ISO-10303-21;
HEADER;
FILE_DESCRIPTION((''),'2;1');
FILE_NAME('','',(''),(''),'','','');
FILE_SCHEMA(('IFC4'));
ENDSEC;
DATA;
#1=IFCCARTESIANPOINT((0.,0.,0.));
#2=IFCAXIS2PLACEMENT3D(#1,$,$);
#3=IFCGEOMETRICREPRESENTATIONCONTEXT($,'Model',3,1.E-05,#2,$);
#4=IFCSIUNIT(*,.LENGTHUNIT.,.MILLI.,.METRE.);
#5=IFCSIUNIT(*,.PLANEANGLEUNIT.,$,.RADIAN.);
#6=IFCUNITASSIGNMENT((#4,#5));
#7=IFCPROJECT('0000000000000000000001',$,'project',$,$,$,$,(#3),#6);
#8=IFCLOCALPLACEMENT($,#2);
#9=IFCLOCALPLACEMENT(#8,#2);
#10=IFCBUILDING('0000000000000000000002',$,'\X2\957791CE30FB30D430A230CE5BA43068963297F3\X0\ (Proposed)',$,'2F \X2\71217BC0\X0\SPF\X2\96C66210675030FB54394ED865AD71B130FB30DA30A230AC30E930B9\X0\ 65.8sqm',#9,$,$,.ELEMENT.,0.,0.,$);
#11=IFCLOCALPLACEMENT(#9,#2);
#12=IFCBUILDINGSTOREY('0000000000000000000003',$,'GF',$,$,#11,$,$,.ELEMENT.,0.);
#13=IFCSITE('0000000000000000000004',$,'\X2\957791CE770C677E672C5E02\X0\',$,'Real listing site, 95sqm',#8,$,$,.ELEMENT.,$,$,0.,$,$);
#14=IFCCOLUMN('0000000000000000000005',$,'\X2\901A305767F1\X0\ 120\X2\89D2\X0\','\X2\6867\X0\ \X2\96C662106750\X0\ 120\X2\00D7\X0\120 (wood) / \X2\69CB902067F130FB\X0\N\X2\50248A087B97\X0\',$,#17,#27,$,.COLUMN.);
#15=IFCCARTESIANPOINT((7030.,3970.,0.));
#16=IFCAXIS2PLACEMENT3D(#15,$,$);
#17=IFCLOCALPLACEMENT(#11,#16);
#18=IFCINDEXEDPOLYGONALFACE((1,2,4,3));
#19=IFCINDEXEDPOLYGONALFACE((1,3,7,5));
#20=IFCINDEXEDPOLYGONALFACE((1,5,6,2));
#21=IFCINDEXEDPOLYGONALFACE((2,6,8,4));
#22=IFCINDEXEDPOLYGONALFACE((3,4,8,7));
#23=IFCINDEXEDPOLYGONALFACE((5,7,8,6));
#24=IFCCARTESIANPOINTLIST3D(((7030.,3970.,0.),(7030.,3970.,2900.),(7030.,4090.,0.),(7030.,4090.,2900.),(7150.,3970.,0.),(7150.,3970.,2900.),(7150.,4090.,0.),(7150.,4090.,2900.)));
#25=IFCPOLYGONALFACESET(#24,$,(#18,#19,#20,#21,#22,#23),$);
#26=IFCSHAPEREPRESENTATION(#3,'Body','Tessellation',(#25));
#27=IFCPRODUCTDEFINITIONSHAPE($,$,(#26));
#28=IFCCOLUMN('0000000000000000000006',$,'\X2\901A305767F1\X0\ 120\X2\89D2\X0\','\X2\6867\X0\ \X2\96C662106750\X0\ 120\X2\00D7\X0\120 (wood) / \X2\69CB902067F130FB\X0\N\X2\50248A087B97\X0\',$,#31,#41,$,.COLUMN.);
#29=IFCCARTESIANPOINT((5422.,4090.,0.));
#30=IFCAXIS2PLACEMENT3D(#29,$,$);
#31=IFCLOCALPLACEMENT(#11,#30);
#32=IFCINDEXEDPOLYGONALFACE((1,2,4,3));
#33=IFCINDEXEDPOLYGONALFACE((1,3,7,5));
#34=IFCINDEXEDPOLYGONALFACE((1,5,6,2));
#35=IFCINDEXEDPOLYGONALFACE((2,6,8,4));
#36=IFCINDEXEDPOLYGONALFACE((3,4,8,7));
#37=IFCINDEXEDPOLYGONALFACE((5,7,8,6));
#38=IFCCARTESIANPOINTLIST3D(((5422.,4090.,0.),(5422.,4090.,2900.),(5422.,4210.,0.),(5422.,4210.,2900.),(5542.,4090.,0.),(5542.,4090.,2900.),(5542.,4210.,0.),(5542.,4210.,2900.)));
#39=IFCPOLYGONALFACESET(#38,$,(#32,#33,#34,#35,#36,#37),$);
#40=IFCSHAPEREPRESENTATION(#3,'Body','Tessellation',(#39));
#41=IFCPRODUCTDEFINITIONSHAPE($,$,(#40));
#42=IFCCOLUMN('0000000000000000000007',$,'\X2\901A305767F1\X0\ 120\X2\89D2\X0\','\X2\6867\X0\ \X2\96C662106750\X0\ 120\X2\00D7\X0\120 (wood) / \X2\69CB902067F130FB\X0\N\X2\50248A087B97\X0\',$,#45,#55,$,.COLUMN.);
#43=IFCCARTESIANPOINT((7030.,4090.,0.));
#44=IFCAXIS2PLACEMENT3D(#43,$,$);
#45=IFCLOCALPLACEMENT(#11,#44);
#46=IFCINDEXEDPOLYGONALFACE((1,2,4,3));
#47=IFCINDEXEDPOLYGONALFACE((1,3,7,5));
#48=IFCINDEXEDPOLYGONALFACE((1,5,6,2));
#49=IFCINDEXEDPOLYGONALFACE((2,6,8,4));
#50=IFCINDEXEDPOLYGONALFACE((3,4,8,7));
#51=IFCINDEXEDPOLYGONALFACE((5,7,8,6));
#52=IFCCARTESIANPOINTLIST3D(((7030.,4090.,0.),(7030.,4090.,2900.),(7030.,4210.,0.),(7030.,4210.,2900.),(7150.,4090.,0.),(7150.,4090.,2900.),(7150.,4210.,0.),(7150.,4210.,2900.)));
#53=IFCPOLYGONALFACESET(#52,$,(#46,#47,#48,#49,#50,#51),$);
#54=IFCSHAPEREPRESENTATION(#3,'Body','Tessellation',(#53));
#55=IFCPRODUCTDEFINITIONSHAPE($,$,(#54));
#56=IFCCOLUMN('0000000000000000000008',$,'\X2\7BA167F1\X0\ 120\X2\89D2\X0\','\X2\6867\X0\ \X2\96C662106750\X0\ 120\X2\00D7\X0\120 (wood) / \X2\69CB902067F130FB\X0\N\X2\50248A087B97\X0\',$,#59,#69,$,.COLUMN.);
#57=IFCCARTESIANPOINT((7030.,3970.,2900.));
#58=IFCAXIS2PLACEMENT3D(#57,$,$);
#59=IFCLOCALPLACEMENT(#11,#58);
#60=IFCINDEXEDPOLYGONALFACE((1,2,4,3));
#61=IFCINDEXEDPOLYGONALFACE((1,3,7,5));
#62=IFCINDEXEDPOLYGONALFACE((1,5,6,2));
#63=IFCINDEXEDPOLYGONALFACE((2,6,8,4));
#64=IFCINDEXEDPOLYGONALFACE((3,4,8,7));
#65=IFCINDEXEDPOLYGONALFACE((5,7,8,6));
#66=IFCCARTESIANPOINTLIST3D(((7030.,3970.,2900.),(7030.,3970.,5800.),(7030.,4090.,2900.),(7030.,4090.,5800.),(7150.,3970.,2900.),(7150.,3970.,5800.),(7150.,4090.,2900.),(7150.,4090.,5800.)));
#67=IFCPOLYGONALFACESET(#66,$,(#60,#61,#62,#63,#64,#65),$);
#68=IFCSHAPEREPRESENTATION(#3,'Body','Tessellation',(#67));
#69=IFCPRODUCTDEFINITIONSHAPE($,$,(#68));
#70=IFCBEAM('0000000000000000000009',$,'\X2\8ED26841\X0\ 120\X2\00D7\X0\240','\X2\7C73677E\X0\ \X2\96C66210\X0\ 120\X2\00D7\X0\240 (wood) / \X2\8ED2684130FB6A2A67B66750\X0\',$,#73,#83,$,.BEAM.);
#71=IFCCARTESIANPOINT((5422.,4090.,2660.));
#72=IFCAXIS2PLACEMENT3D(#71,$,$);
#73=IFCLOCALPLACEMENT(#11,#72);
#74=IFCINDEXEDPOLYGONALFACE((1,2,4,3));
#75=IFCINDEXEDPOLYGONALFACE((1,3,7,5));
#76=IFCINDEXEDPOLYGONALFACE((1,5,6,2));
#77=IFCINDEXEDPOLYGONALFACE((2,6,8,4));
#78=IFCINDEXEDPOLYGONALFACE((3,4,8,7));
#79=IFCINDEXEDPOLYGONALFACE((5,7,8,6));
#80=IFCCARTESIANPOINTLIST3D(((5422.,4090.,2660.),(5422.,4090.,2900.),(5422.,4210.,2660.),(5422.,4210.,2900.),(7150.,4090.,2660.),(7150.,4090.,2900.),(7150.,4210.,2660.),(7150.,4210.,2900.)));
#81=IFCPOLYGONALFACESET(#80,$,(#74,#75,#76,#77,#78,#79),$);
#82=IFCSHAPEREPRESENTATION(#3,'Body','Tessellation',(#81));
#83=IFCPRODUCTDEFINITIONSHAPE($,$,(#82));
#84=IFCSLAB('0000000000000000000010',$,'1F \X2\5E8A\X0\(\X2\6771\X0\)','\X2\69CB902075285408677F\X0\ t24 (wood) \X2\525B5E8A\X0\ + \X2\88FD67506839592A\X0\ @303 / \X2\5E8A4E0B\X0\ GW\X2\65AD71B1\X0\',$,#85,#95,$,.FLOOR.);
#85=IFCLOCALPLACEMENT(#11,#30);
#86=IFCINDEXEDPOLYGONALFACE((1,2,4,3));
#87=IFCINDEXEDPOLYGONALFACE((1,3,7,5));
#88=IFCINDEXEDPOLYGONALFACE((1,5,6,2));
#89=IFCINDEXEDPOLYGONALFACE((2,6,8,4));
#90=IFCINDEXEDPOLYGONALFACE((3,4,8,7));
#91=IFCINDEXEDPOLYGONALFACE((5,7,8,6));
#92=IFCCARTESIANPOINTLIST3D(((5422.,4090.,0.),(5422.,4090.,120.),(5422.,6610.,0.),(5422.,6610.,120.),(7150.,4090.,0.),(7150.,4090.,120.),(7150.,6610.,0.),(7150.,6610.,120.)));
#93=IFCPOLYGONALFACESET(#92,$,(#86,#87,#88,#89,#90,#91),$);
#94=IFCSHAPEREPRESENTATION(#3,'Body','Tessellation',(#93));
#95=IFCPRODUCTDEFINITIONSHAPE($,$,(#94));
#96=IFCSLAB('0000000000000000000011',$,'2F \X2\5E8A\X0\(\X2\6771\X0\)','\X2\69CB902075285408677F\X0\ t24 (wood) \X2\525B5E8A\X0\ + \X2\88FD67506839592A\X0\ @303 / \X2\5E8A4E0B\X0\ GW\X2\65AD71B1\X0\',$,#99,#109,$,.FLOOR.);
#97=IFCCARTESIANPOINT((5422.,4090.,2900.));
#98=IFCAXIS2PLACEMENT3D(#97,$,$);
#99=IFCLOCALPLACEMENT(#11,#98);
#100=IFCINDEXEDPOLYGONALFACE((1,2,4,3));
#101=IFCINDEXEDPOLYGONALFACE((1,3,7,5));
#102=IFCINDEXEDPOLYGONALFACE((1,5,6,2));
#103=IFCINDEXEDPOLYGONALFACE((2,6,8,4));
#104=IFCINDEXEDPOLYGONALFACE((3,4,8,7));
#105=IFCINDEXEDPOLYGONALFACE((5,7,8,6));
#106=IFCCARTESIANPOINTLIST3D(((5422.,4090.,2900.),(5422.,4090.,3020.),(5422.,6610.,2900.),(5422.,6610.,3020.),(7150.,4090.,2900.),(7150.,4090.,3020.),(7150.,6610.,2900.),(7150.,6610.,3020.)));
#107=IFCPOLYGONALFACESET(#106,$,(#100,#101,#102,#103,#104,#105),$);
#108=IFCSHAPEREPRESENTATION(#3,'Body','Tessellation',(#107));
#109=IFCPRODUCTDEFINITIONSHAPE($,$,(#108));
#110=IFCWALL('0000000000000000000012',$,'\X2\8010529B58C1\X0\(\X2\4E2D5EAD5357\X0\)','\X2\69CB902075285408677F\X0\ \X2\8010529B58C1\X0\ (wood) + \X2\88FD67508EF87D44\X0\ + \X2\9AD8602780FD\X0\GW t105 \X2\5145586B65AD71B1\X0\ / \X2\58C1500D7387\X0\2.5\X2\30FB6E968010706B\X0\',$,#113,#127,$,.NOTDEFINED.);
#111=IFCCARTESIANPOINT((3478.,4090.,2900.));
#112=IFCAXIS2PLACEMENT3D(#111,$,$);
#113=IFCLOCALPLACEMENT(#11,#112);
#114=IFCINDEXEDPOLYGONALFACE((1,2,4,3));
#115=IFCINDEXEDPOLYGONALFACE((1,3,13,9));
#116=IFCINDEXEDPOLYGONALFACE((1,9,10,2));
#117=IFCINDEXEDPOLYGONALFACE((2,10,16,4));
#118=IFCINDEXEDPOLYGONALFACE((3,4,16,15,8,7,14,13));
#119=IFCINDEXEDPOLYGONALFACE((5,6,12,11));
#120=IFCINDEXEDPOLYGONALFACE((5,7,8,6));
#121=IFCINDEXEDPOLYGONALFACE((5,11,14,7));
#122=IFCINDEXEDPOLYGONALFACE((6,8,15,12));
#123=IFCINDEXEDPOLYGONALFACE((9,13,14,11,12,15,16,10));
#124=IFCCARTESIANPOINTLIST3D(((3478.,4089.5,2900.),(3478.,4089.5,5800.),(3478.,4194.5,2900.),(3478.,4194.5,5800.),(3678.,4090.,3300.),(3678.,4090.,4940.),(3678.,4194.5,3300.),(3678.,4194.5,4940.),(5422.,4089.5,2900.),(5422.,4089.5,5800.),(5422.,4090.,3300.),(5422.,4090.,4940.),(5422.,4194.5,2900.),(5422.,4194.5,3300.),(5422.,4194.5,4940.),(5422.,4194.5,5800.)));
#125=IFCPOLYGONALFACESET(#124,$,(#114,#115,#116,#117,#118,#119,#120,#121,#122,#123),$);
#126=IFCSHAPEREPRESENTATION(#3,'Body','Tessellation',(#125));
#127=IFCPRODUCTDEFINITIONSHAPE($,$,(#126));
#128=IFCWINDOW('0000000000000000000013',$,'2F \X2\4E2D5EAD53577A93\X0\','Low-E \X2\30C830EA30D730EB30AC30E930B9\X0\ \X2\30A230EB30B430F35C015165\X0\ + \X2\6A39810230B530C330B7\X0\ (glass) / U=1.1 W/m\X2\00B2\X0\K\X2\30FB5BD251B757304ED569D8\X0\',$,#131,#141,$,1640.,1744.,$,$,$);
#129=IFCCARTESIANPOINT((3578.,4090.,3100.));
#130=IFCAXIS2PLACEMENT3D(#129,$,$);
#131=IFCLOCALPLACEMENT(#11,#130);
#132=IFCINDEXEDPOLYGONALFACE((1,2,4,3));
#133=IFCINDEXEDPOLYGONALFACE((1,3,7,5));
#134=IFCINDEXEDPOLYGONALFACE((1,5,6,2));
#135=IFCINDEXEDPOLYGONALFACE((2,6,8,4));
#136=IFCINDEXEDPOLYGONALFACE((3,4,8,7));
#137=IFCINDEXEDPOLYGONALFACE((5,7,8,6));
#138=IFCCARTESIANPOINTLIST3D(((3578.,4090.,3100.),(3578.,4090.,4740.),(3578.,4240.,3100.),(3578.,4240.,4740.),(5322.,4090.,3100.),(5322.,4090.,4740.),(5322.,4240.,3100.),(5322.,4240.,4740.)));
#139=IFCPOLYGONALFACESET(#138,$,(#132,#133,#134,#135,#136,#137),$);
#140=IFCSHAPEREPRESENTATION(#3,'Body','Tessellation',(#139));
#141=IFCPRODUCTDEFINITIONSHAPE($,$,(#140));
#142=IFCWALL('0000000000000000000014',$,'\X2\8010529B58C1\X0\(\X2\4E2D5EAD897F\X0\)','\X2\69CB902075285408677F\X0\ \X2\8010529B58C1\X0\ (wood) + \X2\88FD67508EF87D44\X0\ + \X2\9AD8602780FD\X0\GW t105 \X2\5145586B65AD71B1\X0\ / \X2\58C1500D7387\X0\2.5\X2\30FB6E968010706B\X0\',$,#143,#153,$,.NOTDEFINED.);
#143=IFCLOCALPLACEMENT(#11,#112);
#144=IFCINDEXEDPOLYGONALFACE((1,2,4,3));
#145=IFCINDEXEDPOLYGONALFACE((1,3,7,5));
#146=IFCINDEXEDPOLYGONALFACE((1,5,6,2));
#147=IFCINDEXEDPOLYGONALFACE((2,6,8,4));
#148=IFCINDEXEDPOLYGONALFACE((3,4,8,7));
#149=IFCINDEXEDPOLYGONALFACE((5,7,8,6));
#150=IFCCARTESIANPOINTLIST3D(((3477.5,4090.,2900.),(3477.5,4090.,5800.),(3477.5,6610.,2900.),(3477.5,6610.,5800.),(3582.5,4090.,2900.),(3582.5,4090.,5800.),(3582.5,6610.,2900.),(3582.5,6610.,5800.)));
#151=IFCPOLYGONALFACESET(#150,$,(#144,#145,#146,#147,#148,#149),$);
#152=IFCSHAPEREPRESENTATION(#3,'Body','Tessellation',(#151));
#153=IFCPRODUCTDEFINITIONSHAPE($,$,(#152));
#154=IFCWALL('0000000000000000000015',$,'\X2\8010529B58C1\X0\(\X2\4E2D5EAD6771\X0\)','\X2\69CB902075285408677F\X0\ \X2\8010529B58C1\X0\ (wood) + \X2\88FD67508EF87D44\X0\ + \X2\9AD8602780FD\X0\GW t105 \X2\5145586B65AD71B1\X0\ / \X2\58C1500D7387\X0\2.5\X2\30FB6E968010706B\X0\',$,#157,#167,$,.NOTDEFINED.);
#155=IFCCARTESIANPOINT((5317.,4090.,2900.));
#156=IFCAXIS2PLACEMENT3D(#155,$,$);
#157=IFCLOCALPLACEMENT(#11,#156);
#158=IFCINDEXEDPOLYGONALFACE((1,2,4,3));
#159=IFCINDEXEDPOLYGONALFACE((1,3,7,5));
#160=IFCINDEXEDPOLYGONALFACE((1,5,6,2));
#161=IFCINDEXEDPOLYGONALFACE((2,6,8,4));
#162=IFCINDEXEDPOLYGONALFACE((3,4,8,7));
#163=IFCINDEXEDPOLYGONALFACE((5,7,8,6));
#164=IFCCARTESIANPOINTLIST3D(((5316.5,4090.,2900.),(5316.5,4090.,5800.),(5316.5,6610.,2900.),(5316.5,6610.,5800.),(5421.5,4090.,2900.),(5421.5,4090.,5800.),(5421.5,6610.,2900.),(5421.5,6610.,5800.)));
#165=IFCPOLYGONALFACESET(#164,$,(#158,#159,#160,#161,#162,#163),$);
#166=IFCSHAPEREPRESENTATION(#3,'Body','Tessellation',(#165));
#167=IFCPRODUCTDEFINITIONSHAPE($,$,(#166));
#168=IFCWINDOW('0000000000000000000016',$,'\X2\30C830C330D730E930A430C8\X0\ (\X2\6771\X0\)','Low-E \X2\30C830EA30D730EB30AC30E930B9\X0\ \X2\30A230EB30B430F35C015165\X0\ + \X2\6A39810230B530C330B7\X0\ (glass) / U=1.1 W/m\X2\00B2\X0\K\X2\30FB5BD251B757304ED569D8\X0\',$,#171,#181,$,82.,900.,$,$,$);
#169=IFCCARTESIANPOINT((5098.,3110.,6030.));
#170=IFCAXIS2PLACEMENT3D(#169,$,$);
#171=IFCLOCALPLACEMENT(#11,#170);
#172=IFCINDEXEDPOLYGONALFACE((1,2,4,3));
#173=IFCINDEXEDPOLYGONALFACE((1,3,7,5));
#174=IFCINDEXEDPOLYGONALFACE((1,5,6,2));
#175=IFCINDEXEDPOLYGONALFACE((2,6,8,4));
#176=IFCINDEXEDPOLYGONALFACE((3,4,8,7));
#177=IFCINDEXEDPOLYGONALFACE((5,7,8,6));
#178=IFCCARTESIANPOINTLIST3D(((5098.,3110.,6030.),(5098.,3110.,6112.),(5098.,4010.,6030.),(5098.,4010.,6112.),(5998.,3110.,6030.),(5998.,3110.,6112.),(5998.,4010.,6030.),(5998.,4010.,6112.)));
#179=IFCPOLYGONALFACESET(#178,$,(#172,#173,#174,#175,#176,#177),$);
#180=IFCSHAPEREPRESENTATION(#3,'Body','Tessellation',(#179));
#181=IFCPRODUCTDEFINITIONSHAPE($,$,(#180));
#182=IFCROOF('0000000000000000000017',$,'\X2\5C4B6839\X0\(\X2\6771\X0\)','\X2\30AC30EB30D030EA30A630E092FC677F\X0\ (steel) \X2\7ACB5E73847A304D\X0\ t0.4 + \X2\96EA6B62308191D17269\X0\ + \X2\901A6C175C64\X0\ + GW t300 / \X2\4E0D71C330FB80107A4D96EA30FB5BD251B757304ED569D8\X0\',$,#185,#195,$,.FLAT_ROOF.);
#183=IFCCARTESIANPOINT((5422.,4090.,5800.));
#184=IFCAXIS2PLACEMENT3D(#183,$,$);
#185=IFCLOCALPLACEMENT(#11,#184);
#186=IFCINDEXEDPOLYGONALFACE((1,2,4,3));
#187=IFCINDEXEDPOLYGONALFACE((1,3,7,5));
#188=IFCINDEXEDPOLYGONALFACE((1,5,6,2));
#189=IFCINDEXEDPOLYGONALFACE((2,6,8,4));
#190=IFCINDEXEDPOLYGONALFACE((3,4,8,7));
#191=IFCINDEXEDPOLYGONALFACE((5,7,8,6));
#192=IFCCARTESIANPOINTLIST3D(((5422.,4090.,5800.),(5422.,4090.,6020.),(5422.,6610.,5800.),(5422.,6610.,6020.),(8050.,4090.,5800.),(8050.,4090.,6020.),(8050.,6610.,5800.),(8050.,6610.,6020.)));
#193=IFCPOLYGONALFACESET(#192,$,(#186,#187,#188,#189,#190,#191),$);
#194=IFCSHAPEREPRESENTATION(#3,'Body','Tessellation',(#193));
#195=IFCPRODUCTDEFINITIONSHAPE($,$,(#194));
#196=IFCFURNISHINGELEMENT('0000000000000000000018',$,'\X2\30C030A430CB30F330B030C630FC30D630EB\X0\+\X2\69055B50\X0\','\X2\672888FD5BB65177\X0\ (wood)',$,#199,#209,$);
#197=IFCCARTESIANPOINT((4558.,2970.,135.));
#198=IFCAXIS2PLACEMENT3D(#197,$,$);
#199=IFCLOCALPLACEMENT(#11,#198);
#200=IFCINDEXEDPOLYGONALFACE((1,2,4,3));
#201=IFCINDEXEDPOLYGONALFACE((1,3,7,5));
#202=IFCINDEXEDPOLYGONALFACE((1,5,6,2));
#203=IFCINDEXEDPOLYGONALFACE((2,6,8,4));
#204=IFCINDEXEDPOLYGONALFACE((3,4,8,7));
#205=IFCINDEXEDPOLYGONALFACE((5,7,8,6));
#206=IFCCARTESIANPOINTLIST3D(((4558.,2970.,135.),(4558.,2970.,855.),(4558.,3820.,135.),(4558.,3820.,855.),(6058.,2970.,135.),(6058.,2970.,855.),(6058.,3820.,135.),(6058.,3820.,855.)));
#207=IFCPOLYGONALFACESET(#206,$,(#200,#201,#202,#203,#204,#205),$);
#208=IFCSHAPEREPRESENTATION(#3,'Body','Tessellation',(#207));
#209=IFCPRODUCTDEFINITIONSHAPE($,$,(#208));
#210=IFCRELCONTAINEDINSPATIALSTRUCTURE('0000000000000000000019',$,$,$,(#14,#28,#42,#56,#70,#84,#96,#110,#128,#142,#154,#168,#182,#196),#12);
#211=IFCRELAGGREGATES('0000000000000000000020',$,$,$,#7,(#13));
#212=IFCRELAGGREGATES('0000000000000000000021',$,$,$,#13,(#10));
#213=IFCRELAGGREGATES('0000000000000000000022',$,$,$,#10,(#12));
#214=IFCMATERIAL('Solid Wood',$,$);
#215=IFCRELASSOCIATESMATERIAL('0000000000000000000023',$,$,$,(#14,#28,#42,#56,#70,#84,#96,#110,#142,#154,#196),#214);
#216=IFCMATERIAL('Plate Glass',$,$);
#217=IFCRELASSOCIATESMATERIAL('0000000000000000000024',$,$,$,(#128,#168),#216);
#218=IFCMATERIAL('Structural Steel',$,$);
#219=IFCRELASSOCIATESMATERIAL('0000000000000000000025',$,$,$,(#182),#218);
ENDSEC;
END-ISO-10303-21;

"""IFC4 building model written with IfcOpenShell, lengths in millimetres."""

from ifc_helpers import new_model, si_unit, frame, frame_2d, origin, place, context, project, spatial, rectangle, extrude, material, element, fill, save


model = new_model("IFC4")

# Units and contexts
model_context = context("Model", 3, precision=1e-05, world=origin())
ifc_project = project(units=[si_unit("LENGTHUNIT", "METRE", prefix="MILLI"), si_unit("PLANEANGLEUNIT", "RADIAN")], contexts=[model_context])

# Site, building, storey
site_placement = place(None, origin())
site = spatial("IfcSite", under=ifc_project, at=site_placement, Name="長野県松本市", ObjectType="Real listing site, 95sqm", CompositionType="ELEMENT", RefElevation=0.0)
building_placement = place(site_placement, origin())
building = spatial("IfcBuilding", under=site, at=building_placement, Name="長野・ピアノ室と防音 (Proposed)", ObjectType="2F 無節SPF集成材・吹付断熱・ペアガラス 65.8sqm", CompositionType="ELEMENT", ElevationOfRefHeight=0.0, ElevationOfTerrain=0.0)
storey_placement = place(building_placement, origin())
storey = spatial("IfcBuildingStorey", under=building, at=storey_placement, Name="GF", CompositionType="ELEMENT", Elevation=0.0)

# Columns
ifc_material_1 = material(Name="Solid Wood")
column_1_placement = place(storey_placement, frame((7030.0, 3970.0, 0.0)))
element("IfcColumn", 1, at=column_1_placement, inside=storey, material=ifc_material_1, Name="通し柱 120角", Description="桧 集成材 120×120 (wood) / 構造柱・N値計算", PredefinedType="COLUMN", context=model_context, shape_type="SweptSolid", body=[
    extrude(rectangle(XDim=120.0, YDim=120.0, at=frame_2d((60.0, 60.0))), frame((7030.0, 3970.0, 0.0)), (0.0, 0.0, 1.0), 2900.0),
])
column_2_placement = place(storey_placement, frame((5422.0, 4090.0, 0.0)))
element("IfcColumn", 2, at=column_2_placement, inside=storey, material=ifc_material_1, Name="通し柱 120角", Description="桧 集成材 120×120 (wood) / 構造柱・N値計算", PredefinedType="COLUMN", context=model_context, shape_type="SweptSolid", body=[
    extrude(rectangle(XDim=120.0, YDim=120.0, at=frame_2d((60.0, 60.0))), frame((5422.0, 4090.0, 0.0)), (0.0, 0.0, 1.0), 2900.0),
])
column_3_placement = place(storey_placement, frame((7030.0, 4090.0, 0.0)))
element("IfcColumn", 3, at=column_3_placement, inside=storey, material=ifc_material_1, Name="通し柱 120角", Description="桧 集成材 120×120 (wood) / 構造柱・N値計算", PredefinedType="COLUMN", context=model_context, shape_type="SweptSolid", body=[
    extrude(rectangle(XDim=120.0, YDim=120.0, at=frame_2d((60.0, 60.0))), frame((7030.0, 4090.0, 0.0)), (0.0, 0.0, 1.0), 2900.0),
])
column_4_placement = place(storey_placement, frame((7030.0, 3970.0, 2900.0)))
element("IfcColumn", 4, at=column_4_placement, inside=storey, material=ifc_material_1, Name="管柱 120角", Description="桧 集成材 120×120 (wood) / 構造柱・N値計算", PredefinedType="COLUMN", context=model_context, shape_type="SweptSolid", body=[
    extrude(rectangle(XDim=120.0, YDim=120.0, at=frame_2d((60.0, 60.0))), frame((7030.0, 3970.0, 2900.0)), (0.0, 0.0, 1.0), 2900.0),
])

# Beam
beam_1_placement = place(storey_placement, frame((5422.0, 4090.0, 2660.0)))
element("IfcBeam", 5, at=beam_1_placement, inside=storey, material=ifc_material_1, Name="軒桁 120×240", Description="米松 集成 120×240 (wood) / 軒桁・横架材", PredefinedType="BEAM", context=model_context, shape_type="SweptSolid", body=[
    extrude(rectangle(XDim=1728.0, YDim=120.0, at=frame_2d((864.0, 60.0))), frame((5422.0, 4090.0, 2660.0)), (0.0, 0.0, 1.0), 240.0),
])

# Slabs
slab_1_placement = place(storey_placement, frame((5422.0, 4090.0, 0.0)))
element("IfcSlab", 6, at=slab_1_placement, inside=storey, material=ifc_material_1, Name="1F 床(東)", Description="構造用合板 t24 (wood) 剛床 + 製材根太 @303 / 床下 GW断熱", PredefinedType="FLOOR", context=model_context, shape_type="SweptSolid", body=[
    extrude(rectangle(XDim=1728.0, YDim=2520.0, at=frame_2d((864.0, 1260.0))), frame((5422.0, 4090.0, 0.0)), (0.0, 0.0, 1.0), 120.0),
])
slab_2_placement = place(storey_placement, frame((5422.0, 4090.0, 2900.0)))
element("IfcSlab", 7, at=slab_2_placement, inside=storey, material=ifc_material_1, Name="2F 床(東)", Description="構造用合板 t24 (wood) 剛床 + 製材根太 @303 / 床下 GW断熱", PredefinedType="FLOOR", context=model_context, shape_type="SweptSolid", body=[
    extrude(rectangle(XDim=1728.0, YDim=2520.0, at=frame_2d((864.0, 1260.0))), frame((5422.0, 4090.0, 2900.0)), (0.0, 0.0, 1.0), 120.0),
])

# Wall, opening, window
wall_1_placement = place(storey_placement, frame((3478.0, 4090.0, 2900.0)))
wall_1 = element("IfcWall", 8, at=wall_1_placement, inside=storey, material=ifc_material_1, Name="耐力壁(中庭南)", Description="構造用合板 耐力壁 (wood) + 製材軸組 + 高性能GW t105 充填断熱 / 壁倍率2.5・準耐火", PredefinedType="NOTDEFINED", context=model_context, shape_type="SweptSolid", body=[
    extrude(rectangle(XDim=1944.0, YDim=105.0, at=frame_2d((972.0, 52.0))), frame((3478.0, 4090.0, 2900.0)), (0.0, 0.0, 1.0), 2900.0),
])
opening_placement = place(storey_placement, frame((3578.0, 4090.0, 3100.0)))
opening = element("IfcOpeningElement", 9, at=opening_placement, cuts=wall_1, PredefinedType="NOTDEFINED", context=model_context, shape_type="SweptSolid", body=[
    extrude(rectangle(XDim=1744.0, YDim=150.0, at=frame_2d((872.0, 75.0))), frame((3578.0, 4090.0, 3100.0)), (0.0, 0.0, 1.0), 1640.0),
])
ifc_material_2 = material(Name="Plate Glass")
window_1_placement = place(storey_placement, frame((3578.0, 4090.0, 3100.0)))
window_1 = element("IfcWindow", 10, at=window_1_placement, inside=storey, material=ifc_material_2, Name="2F 中庭南窓", Description="Low-E トリプルガラス アルゴン封入 + 樹脂サッシ (glass) / U=1.1 W/m²K・寒冷地仕様", OverallHeight=1640.0, OverallWidth=1744.0, context=model_context, shape_type="SweptSolid", body=[
    extrude(rectangle(XDim=1744.0, YDim=150.0, at=frame_2d((872.0, 75.0))), frame((3578.0, 4090.0, 3100.0)), (0.0, 0.0, 1.0), 1640.0),
])
fill(opening, window_1)

# Walls
wall_2_placement = place(storey_placement, frame((3478.0, 4090.0, 2900.0)))
element("IfcWall", 11, at=wall_2_placement, inside=storey, material=ifc_material_1, Name="耐力壁(中庭西)", Description="構造用合板 耐力壁 (wood) + 製材軸組 + 高性能GW t105 充填断熱 / 壁倍率2.5・準耐火", PredefinedType="NOTDEFINED", context=model_context, shape_type="SweptSolid", body=[
    extrude(rectangle(XDim=105.0, YDim=2520.0, at=frame_2d((52.0, 1260.0))), frame((3478.0, 4090.0, 2900.0)), (0.0, 0.0, 1.0), 2900.0),
])
wall_3_placement = place(storey_placement, frame((5317.0, 4090.0, 2900.0)))
element("IfcWall", 12, at=wall_3_placement, inside=storey, material=ifc_material_1, Name="耐力壁(中庭東)", Description="構造用合板 耐力壁 (wood) + 製材軸組 + 高性能GW t105 充填断熱 / 壁倍率2.5・準耐火", PredefinedType="NOTDEFINED", context=model_context, shape_type="SweptSolid", body=[
    extrude(rectangle(XDim=105.0, YDim=2520.0, at=frame_2d((52.0, 1260.0))), frame((5317.0, 4090.0, 2900.0)), (0.0, 0.0, 1.0), 2900.0),
])

# Window
window_2_placement = place(storey_placement, frame((5098.0, 3110.0, 6030.0)))
element("IfcWindow", 13, at=window_2_placement, inside=storey, material=ifc_material_2, Name="トップライト (東)", Description="Low-E トリプルガラス アルゴン封入 + 樹脂サッシ (glass) / U=1.1 W/m²K・寒冷地仕様", OverallHeight=82.0, OverallWidth=900.0, context=model_context, shape_type="SweptSolid", body=[
    extrude(rectangle(XDim=900.0, YDim=900.0, at=frame_2d((450.0, 450.0))), frame((5098.0, 3110.0, 6030.0)), (0.0, 0.0, 1.0), 82.0),
])

# Roof
ifc_material_3 = material(Name="Structural Steel")
for number, where, name in (
    (14, (5422.0, 4090.0, 5800.0), "屋根(東)"),
):
    element("IfcRoof", number, at=place(storey_placement, frame(where)), inside=storey, material=ifc_material_3, Name=name, Description="ガルバリウム鋼板 (steel) 立平葺き t0.4 + 雪止め金物 + 通気層 + GW t300 / 不燃・耐積雪・寒冷地仕様", PredefinedType="FLAT_ROOF", context=model_context, shape_type="SweptSolid", body=[
        extrude(rectangle(XDim=2628.0, YDim=2520.0, at=frame_2d((1314.0, 1260.0))), frame((5422.0, 4090.0, 5800.0)), (0.0, 0.0, 1.0), 220.0),
    ])

# Furnishing element
furnishing_1_placement = place(storey_placement, frame((4558.0, 2970.0, 135.0)))
element("IfcFurnishingElement", 15, at=furnishing_1_placement, inside=storey, material=ifc_material_1, Name="ダイニングテーブル+椅子", Description="木製家具 (wood)", context=model_context, shape_type="SweptSolid", body=[
    extrude(rectangle(XDim=1500.0, YDim=850.0, at=frame_2d((750.0, 425.0))), frame((4558.0, 2970.0, 135.0)), (0.0, 0.0, 1.0), 720.0),
])

save(model, "model.ifc")
